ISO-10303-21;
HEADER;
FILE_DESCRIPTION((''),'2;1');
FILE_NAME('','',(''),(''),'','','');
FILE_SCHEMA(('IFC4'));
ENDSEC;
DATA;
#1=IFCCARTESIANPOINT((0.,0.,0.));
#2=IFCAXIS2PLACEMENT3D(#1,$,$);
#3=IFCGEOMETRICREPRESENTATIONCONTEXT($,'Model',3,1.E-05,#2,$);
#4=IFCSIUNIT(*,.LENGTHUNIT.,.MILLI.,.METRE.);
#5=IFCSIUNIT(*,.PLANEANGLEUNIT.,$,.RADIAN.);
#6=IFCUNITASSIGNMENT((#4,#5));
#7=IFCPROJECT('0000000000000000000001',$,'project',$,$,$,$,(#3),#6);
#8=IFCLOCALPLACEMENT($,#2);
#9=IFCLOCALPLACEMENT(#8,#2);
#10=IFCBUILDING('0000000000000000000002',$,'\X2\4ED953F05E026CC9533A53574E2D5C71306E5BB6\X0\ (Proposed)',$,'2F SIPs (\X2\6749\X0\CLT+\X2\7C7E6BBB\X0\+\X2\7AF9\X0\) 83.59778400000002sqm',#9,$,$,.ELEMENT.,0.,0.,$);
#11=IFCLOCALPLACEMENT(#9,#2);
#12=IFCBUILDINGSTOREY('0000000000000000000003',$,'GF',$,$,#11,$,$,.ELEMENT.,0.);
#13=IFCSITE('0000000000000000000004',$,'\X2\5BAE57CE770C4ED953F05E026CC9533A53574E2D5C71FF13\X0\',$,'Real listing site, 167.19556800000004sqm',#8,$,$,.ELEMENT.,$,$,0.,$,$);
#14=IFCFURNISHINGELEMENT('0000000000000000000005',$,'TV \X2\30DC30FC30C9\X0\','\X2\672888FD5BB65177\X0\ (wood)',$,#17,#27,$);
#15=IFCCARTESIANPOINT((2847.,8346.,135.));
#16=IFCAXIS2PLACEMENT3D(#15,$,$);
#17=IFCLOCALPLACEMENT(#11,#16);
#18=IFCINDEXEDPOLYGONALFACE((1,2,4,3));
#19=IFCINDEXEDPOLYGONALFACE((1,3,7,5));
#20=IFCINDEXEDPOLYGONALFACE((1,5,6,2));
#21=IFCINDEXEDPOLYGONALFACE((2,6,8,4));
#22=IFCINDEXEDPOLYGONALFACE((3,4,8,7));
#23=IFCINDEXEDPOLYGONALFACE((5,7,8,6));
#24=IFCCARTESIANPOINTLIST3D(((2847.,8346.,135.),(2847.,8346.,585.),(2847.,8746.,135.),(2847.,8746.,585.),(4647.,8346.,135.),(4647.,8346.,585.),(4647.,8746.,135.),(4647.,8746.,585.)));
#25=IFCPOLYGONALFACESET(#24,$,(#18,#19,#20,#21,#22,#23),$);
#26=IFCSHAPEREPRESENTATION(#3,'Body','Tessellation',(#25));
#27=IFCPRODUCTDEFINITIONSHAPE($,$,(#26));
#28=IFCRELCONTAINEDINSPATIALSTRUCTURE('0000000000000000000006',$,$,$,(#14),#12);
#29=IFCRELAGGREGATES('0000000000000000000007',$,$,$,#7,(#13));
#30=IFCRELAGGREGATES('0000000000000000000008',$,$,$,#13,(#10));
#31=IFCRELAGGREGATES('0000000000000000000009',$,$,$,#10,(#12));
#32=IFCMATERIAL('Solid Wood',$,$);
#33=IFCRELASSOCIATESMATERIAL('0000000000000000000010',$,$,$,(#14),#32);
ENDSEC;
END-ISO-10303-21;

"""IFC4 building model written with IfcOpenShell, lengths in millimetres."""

from ifc_helpers import new_model, si_unit, frame, frame_2d, origin, place, context, project, spatial, rectangle, extrude, material, element, save


model = new_model("IFC4")

# Units and contexts
model_context = context("Model", 3, precision=1e-05, world=origin())
ifc_project = project(units=[si_unit("LENGTHUNIT", "METRE", prefix="MILLI"), si_unit("PLANEANGLEUNIT", "RADIAN")], contexts=[model_context])

# Site, building, storey
site_placement = place(None, origin())
site = spatial("IfcSite", under=ifc_project, at=site_placement, Name="宮城県仙台市泉区南中山３", ObjectType="Real listing site, 167.19556800000004sqm", CompositionType="ELEMENT", RefElevation=0.0)
building_placement = place(site_placement, origin())
building = spatial("IfcBuilding", under=site, at=building_placement, Name="仙台市泉区南中山の家 (Proposed)", ObjectType="2F SIPs (杉CLT+籾殻+竹) 83.59778400000002sqm", CompositionType="ELEMENT", ElevationOfRefHeight=0.0, ElevationOfTerrain=0.0)
storey_placement = place(building_placement, origin())
storey = spatial("IfcBuildingStorey", under=building, at=storey_placement, Name="GF", CompositionType="ELEMENT", Elevation=0.0)

# Shared definitions
ifc_material_1 = material(Name="Solid Wood")

# Furnishing element
furnishing_placement = place(storey_placement, frame((2847.0, 8346.0, 135.0)))
element("IfcFurnishingElement", 1, at=furnishing_placement, inside=storey, material=ifc_material_1, Name="TV ボード", Description="木製家具 (wood)", context=model_context, shape_type="SweptSolid", body=[
    extrude(rectangle(XDim=1800.0, YDim=400.0, at=frame_2d((900.0, 200.0))), frame((2847.0, 8346.0, 135.0)), (0.0, 0.0, 1.0), 450.0),
])

save(model, "model.ifc")
